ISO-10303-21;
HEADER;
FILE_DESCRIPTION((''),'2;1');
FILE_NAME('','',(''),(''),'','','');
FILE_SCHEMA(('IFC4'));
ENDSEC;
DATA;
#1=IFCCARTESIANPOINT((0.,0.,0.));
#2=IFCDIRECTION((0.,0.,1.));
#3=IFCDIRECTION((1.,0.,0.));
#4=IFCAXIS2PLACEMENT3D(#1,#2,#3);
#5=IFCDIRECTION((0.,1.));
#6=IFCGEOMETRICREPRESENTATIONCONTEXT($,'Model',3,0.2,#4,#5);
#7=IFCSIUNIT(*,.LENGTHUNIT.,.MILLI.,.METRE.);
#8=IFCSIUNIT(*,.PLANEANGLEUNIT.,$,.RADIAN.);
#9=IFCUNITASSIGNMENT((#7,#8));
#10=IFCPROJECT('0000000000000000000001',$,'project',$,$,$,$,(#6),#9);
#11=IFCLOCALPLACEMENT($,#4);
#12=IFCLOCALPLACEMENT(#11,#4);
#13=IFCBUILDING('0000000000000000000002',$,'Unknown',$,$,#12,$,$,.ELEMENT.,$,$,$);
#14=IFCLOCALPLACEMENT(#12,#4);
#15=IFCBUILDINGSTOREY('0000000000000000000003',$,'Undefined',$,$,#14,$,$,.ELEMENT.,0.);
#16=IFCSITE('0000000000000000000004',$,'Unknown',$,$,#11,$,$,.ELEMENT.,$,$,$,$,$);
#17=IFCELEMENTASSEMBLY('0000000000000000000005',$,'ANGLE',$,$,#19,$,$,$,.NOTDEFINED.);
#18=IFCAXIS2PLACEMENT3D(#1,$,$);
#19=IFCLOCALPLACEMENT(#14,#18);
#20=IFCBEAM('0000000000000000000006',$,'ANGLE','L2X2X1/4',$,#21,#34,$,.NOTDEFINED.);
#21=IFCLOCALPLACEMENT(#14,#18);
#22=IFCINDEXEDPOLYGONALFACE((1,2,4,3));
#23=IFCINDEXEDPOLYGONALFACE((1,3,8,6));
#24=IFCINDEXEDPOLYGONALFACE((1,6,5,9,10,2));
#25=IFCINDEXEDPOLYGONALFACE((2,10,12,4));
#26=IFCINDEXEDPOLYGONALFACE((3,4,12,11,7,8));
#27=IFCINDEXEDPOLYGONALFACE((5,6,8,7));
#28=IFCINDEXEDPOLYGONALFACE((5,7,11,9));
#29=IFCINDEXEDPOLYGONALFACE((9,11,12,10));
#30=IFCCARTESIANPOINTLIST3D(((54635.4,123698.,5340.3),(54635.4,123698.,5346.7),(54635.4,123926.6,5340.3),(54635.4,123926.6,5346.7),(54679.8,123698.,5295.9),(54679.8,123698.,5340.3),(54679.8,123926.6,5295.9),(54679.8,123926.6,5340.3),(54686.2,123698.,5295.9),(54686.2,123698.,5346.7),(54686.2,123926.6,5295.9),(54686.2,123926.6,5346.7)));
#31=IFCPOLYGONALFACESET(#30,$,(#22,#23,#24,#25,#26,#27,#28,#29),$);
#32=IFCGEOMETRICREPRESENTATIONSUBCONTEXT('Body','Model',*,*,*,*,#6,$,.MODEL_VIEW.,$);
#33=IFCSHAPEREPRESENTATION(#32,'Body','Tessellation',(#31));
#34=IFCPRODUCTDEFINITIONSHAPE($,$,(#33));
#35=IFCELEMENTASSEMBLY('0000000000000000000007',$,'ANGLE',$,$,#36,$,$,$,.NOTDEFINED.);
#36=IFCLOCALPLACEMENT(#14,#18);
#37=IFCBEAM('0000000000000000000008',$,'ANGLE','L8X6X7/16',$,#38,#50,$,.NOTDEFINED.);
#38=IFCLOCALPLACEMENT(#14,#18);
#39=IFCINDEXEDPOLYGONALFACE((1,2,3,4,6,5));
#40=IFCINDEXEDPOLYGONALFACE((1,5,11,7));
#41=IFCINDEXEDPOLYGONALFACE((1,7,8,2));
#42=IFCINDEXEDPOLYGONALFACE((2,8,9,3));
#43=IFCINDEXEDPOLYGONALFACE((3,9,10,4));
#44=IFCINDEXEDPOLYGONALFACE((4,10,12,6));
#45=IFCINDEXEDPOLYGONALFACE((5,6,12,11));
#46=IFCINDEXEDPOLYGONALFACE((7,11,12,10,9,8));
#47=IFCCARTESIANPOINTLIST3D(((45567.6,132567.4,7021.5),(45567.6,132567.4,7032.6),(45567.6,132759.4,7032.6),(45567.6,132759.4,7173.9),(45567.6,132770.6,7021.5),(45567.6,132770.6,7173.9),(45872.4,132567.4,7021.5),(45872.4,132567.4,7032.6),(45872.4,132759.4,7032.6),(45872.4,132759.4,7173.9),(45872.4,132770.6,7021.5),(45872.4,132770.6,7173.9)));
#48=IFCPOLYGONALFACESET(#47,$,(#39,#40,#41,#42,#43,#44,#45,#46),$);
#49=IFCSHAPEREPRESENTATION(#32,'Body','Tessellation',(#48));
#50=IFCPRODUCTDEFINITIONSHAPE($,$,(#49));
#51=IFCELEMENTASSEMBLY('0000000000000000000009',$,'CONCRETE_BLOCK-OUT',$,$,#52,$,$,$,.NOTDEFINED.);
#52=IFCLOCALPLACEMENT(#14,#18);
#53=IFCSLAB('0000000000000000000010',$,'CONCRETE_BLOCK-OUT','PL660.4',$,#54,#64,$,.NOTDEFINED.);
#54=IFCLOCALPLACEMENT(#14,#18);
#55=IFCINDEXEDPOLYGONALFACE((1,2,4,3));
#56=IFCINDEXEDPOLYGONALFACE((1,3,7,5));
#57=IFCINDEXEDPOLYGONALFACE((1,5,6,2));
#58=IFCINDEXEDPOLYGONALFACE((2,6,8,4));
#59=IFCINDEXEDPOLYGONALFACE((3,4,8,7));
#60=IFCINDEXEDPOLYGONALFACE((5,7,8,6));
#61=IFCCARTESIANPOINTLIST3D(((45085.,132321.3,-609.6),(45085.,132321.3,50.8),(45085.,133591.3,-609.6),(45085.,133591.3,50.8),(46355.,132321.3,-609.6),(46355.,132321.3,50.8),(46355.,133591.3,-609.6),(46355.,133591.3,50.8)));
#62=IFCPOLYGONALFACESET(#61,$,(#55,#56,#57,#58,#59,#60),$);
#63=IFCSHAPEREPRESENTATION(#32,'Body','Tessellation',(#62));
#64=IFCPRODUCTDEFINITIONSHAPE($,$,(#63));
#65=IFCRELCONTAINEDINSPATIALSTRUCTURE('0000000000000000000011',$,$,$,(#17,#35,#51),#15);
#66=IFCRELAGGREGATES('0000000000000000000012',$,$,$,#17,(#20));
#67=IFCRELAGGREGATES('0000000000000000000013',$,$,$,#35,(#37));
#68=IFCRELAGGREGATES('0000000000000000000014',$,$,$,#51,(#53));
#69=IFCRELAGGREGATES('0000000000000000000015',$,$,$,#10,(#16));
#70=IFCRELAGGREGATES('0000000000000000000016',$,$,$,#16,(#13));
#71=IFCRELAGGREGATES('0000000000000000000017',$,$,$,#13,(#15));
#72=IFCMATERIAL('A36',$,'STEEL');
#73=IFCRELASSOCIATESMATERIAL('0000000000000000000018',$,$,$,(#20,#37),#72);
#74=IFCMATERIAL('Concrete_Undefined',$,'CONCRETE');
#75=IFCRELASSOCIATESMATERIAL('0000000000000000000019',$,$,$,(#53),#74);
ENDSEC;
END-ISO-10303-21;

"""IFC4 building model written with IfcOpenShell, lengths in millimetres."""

from ifc_helpers import new_model, si_unit, direction, frame, origin_with_axes, place, context, subcontext, project, spatial, line, indexed_curve, outline, extrude, material, element, aggregate, save


model = new_model("IFC4")

# Units and contexts
model_context = context("Model", 3, precision=0.2, world=origin_with_axes(), true_north=direction((0.0, 1.0)))
body_context = subcontext(model_context, "Body", "Model", "MODEL_VIEW")
ifc_project = project(units=[si_unit("LENGTHUNIT", "METRE", prefix="MILLI"), si_unit("PLANEANGLEUNIT", "RADIAN")], contexts=[model_context])

# Site, building, storey
site_placement = place(None, origin_with_axes())
site = spatial("IfcSite", under=ifc_project, at=site_placement, Name="Unknown", CompositionType="ELEMENT")
building_placement = place(site_placement, origin_with_axes())
building = spatial("IfcBuilding", under=site, at=building_placement, Name="Unknown", CompositionType="ELEMENT")
storey_placement = place(building_placement, origin_with_axes())
storey = spatial("IfcBuildingStorey", under=building, at=storey_placement, Name="Undefined", CompositionType="ELEMENT", Elevation=0.0)

# Element assemblies, beams
assembly_1_placement = place(storey_placement, frame((54660.8, 123926.6, 5321.3), z_axis=(0.0, 0.0, -1.0), x_axis=(0.0, -1.0, 0.0)))
assembly_1 = element("IfcElementAssembly", 1, at=assembly_1_placement, inside=storey, Name="ANGLE", PredefinedType="NOTDEFINED")
ifc_material_1 = material(Name="A36", Category="STEEL")
beam_1_placement = place(assembly_1_placement, origin_with_axes())
beam_1 = element("IfcBeam", 2, at=beam_1_placement, material=ifc_material_1, Name="ANGLE", Description="L2X2X1/4", PredefinedType="NOTDEFINED", context=body_context, shape_type="SolidModel", body=[
    extrude(outline(indexed_curve([(-25.4, -25.4), (25.4, -25.4), (25.4, -19.1), (-19.1, -19.1), (-19.1, 25.4), (-25.4, 25.4)], segments=[line(1, 2, 3, 4, 5, 6, 1)])), frame((0.0, 0.0, 0.0), z_axis=(-1.0, 0.0, 0.0), x_axis=(0.0, 0.0, 1.0)), (0.0, 0.0, -1.0), 228.6),
])
aggregate(assembly_1, [beam_1])
assembly_2_placement = place(storey_placement, frame((45872.4, 132669.0, 7097.7), z_axis=(0.0, 0.0, 1.0), x_axis=(-1.0, 0.000019, 0.0)))
assembly_2 = element("IfcElementAssembly", 3, at=assembly_2_placement, inside=storey, Name="ANGLE", PredefinedType="NOTDEFINED")
beam_2_placement = place(assembly_2_placement, origin_with_axes())
beam_2 = element("IfcBeam", 4, at=beam_2_placement, material=ifc_material_1, Name="ANGLE", Description="L8X6X7/16", PredefinedType="NOTDEFINED", context=body_context, shape_type="SolidModel", body=[
    extrude(outline(indexed_curve([(-76.2, -101.6), (76.2, -101.6), (76.2, -90.5), (-65.1, -90.5), (-65.1, 101.6), (-76.2, 101.6)], segments=[line(1, 2, 3, 4, 5, 6, 1)])), frame((0.0, 0.0, 0.0), z_axis=(-1.0, 0.0, 0.0), x_axis=(0.0, 0.0, 1.0)), (0.0, 0.0, -1.0), 304.8),
])
aggregate(assembly_2, [beam_2])

# Element assembly, slab
assembly_3_placement = place(storey_placement, frame((46355.0, 133591.3, -279.4), z_axis=(0.0, 0.0, 1.0), x_axis=(-1.0, 0.0, 0.0)))
assembly_3 = element("IfcElementAssembly", 5, at=assembly_3_placement, inside=storey, Name="CONCRETE_BLOCK-OUT", PredefinedType="NOTDEFINED")
ifc_material_2 = material(Name="Concrete_Undefined", Category="CONCRETE")
slab_placement = place(assembly_3_placement, origin_with_axes())
slab = element("IfcSlab", 6, at=slab_placement, material=ifc_material_2, Name="CONCRETE_BLOCK-OUT", Description="PL660.4", PredefinedType="NOTDEFINED", context=body_context, shape_type="SolidModel", body=[
    extrude(outline(indexed_curve([(0.0, 0.0), (1270.0, 0.0), (1270.0, 1270.0), (0.0, 1270.0)], segments=[line(1, 2, 3, 4, 1)])), frame((0.0, 0.0, 330.2), z_axis=(0.0, 0.0, 1.0), x_axis=(1.0, 0.0, 0.0)), (0.0, 0.0, -1.0), 660.4),
])
aggregate(assembly_3, [slab])

save(model, "model.ifc")
